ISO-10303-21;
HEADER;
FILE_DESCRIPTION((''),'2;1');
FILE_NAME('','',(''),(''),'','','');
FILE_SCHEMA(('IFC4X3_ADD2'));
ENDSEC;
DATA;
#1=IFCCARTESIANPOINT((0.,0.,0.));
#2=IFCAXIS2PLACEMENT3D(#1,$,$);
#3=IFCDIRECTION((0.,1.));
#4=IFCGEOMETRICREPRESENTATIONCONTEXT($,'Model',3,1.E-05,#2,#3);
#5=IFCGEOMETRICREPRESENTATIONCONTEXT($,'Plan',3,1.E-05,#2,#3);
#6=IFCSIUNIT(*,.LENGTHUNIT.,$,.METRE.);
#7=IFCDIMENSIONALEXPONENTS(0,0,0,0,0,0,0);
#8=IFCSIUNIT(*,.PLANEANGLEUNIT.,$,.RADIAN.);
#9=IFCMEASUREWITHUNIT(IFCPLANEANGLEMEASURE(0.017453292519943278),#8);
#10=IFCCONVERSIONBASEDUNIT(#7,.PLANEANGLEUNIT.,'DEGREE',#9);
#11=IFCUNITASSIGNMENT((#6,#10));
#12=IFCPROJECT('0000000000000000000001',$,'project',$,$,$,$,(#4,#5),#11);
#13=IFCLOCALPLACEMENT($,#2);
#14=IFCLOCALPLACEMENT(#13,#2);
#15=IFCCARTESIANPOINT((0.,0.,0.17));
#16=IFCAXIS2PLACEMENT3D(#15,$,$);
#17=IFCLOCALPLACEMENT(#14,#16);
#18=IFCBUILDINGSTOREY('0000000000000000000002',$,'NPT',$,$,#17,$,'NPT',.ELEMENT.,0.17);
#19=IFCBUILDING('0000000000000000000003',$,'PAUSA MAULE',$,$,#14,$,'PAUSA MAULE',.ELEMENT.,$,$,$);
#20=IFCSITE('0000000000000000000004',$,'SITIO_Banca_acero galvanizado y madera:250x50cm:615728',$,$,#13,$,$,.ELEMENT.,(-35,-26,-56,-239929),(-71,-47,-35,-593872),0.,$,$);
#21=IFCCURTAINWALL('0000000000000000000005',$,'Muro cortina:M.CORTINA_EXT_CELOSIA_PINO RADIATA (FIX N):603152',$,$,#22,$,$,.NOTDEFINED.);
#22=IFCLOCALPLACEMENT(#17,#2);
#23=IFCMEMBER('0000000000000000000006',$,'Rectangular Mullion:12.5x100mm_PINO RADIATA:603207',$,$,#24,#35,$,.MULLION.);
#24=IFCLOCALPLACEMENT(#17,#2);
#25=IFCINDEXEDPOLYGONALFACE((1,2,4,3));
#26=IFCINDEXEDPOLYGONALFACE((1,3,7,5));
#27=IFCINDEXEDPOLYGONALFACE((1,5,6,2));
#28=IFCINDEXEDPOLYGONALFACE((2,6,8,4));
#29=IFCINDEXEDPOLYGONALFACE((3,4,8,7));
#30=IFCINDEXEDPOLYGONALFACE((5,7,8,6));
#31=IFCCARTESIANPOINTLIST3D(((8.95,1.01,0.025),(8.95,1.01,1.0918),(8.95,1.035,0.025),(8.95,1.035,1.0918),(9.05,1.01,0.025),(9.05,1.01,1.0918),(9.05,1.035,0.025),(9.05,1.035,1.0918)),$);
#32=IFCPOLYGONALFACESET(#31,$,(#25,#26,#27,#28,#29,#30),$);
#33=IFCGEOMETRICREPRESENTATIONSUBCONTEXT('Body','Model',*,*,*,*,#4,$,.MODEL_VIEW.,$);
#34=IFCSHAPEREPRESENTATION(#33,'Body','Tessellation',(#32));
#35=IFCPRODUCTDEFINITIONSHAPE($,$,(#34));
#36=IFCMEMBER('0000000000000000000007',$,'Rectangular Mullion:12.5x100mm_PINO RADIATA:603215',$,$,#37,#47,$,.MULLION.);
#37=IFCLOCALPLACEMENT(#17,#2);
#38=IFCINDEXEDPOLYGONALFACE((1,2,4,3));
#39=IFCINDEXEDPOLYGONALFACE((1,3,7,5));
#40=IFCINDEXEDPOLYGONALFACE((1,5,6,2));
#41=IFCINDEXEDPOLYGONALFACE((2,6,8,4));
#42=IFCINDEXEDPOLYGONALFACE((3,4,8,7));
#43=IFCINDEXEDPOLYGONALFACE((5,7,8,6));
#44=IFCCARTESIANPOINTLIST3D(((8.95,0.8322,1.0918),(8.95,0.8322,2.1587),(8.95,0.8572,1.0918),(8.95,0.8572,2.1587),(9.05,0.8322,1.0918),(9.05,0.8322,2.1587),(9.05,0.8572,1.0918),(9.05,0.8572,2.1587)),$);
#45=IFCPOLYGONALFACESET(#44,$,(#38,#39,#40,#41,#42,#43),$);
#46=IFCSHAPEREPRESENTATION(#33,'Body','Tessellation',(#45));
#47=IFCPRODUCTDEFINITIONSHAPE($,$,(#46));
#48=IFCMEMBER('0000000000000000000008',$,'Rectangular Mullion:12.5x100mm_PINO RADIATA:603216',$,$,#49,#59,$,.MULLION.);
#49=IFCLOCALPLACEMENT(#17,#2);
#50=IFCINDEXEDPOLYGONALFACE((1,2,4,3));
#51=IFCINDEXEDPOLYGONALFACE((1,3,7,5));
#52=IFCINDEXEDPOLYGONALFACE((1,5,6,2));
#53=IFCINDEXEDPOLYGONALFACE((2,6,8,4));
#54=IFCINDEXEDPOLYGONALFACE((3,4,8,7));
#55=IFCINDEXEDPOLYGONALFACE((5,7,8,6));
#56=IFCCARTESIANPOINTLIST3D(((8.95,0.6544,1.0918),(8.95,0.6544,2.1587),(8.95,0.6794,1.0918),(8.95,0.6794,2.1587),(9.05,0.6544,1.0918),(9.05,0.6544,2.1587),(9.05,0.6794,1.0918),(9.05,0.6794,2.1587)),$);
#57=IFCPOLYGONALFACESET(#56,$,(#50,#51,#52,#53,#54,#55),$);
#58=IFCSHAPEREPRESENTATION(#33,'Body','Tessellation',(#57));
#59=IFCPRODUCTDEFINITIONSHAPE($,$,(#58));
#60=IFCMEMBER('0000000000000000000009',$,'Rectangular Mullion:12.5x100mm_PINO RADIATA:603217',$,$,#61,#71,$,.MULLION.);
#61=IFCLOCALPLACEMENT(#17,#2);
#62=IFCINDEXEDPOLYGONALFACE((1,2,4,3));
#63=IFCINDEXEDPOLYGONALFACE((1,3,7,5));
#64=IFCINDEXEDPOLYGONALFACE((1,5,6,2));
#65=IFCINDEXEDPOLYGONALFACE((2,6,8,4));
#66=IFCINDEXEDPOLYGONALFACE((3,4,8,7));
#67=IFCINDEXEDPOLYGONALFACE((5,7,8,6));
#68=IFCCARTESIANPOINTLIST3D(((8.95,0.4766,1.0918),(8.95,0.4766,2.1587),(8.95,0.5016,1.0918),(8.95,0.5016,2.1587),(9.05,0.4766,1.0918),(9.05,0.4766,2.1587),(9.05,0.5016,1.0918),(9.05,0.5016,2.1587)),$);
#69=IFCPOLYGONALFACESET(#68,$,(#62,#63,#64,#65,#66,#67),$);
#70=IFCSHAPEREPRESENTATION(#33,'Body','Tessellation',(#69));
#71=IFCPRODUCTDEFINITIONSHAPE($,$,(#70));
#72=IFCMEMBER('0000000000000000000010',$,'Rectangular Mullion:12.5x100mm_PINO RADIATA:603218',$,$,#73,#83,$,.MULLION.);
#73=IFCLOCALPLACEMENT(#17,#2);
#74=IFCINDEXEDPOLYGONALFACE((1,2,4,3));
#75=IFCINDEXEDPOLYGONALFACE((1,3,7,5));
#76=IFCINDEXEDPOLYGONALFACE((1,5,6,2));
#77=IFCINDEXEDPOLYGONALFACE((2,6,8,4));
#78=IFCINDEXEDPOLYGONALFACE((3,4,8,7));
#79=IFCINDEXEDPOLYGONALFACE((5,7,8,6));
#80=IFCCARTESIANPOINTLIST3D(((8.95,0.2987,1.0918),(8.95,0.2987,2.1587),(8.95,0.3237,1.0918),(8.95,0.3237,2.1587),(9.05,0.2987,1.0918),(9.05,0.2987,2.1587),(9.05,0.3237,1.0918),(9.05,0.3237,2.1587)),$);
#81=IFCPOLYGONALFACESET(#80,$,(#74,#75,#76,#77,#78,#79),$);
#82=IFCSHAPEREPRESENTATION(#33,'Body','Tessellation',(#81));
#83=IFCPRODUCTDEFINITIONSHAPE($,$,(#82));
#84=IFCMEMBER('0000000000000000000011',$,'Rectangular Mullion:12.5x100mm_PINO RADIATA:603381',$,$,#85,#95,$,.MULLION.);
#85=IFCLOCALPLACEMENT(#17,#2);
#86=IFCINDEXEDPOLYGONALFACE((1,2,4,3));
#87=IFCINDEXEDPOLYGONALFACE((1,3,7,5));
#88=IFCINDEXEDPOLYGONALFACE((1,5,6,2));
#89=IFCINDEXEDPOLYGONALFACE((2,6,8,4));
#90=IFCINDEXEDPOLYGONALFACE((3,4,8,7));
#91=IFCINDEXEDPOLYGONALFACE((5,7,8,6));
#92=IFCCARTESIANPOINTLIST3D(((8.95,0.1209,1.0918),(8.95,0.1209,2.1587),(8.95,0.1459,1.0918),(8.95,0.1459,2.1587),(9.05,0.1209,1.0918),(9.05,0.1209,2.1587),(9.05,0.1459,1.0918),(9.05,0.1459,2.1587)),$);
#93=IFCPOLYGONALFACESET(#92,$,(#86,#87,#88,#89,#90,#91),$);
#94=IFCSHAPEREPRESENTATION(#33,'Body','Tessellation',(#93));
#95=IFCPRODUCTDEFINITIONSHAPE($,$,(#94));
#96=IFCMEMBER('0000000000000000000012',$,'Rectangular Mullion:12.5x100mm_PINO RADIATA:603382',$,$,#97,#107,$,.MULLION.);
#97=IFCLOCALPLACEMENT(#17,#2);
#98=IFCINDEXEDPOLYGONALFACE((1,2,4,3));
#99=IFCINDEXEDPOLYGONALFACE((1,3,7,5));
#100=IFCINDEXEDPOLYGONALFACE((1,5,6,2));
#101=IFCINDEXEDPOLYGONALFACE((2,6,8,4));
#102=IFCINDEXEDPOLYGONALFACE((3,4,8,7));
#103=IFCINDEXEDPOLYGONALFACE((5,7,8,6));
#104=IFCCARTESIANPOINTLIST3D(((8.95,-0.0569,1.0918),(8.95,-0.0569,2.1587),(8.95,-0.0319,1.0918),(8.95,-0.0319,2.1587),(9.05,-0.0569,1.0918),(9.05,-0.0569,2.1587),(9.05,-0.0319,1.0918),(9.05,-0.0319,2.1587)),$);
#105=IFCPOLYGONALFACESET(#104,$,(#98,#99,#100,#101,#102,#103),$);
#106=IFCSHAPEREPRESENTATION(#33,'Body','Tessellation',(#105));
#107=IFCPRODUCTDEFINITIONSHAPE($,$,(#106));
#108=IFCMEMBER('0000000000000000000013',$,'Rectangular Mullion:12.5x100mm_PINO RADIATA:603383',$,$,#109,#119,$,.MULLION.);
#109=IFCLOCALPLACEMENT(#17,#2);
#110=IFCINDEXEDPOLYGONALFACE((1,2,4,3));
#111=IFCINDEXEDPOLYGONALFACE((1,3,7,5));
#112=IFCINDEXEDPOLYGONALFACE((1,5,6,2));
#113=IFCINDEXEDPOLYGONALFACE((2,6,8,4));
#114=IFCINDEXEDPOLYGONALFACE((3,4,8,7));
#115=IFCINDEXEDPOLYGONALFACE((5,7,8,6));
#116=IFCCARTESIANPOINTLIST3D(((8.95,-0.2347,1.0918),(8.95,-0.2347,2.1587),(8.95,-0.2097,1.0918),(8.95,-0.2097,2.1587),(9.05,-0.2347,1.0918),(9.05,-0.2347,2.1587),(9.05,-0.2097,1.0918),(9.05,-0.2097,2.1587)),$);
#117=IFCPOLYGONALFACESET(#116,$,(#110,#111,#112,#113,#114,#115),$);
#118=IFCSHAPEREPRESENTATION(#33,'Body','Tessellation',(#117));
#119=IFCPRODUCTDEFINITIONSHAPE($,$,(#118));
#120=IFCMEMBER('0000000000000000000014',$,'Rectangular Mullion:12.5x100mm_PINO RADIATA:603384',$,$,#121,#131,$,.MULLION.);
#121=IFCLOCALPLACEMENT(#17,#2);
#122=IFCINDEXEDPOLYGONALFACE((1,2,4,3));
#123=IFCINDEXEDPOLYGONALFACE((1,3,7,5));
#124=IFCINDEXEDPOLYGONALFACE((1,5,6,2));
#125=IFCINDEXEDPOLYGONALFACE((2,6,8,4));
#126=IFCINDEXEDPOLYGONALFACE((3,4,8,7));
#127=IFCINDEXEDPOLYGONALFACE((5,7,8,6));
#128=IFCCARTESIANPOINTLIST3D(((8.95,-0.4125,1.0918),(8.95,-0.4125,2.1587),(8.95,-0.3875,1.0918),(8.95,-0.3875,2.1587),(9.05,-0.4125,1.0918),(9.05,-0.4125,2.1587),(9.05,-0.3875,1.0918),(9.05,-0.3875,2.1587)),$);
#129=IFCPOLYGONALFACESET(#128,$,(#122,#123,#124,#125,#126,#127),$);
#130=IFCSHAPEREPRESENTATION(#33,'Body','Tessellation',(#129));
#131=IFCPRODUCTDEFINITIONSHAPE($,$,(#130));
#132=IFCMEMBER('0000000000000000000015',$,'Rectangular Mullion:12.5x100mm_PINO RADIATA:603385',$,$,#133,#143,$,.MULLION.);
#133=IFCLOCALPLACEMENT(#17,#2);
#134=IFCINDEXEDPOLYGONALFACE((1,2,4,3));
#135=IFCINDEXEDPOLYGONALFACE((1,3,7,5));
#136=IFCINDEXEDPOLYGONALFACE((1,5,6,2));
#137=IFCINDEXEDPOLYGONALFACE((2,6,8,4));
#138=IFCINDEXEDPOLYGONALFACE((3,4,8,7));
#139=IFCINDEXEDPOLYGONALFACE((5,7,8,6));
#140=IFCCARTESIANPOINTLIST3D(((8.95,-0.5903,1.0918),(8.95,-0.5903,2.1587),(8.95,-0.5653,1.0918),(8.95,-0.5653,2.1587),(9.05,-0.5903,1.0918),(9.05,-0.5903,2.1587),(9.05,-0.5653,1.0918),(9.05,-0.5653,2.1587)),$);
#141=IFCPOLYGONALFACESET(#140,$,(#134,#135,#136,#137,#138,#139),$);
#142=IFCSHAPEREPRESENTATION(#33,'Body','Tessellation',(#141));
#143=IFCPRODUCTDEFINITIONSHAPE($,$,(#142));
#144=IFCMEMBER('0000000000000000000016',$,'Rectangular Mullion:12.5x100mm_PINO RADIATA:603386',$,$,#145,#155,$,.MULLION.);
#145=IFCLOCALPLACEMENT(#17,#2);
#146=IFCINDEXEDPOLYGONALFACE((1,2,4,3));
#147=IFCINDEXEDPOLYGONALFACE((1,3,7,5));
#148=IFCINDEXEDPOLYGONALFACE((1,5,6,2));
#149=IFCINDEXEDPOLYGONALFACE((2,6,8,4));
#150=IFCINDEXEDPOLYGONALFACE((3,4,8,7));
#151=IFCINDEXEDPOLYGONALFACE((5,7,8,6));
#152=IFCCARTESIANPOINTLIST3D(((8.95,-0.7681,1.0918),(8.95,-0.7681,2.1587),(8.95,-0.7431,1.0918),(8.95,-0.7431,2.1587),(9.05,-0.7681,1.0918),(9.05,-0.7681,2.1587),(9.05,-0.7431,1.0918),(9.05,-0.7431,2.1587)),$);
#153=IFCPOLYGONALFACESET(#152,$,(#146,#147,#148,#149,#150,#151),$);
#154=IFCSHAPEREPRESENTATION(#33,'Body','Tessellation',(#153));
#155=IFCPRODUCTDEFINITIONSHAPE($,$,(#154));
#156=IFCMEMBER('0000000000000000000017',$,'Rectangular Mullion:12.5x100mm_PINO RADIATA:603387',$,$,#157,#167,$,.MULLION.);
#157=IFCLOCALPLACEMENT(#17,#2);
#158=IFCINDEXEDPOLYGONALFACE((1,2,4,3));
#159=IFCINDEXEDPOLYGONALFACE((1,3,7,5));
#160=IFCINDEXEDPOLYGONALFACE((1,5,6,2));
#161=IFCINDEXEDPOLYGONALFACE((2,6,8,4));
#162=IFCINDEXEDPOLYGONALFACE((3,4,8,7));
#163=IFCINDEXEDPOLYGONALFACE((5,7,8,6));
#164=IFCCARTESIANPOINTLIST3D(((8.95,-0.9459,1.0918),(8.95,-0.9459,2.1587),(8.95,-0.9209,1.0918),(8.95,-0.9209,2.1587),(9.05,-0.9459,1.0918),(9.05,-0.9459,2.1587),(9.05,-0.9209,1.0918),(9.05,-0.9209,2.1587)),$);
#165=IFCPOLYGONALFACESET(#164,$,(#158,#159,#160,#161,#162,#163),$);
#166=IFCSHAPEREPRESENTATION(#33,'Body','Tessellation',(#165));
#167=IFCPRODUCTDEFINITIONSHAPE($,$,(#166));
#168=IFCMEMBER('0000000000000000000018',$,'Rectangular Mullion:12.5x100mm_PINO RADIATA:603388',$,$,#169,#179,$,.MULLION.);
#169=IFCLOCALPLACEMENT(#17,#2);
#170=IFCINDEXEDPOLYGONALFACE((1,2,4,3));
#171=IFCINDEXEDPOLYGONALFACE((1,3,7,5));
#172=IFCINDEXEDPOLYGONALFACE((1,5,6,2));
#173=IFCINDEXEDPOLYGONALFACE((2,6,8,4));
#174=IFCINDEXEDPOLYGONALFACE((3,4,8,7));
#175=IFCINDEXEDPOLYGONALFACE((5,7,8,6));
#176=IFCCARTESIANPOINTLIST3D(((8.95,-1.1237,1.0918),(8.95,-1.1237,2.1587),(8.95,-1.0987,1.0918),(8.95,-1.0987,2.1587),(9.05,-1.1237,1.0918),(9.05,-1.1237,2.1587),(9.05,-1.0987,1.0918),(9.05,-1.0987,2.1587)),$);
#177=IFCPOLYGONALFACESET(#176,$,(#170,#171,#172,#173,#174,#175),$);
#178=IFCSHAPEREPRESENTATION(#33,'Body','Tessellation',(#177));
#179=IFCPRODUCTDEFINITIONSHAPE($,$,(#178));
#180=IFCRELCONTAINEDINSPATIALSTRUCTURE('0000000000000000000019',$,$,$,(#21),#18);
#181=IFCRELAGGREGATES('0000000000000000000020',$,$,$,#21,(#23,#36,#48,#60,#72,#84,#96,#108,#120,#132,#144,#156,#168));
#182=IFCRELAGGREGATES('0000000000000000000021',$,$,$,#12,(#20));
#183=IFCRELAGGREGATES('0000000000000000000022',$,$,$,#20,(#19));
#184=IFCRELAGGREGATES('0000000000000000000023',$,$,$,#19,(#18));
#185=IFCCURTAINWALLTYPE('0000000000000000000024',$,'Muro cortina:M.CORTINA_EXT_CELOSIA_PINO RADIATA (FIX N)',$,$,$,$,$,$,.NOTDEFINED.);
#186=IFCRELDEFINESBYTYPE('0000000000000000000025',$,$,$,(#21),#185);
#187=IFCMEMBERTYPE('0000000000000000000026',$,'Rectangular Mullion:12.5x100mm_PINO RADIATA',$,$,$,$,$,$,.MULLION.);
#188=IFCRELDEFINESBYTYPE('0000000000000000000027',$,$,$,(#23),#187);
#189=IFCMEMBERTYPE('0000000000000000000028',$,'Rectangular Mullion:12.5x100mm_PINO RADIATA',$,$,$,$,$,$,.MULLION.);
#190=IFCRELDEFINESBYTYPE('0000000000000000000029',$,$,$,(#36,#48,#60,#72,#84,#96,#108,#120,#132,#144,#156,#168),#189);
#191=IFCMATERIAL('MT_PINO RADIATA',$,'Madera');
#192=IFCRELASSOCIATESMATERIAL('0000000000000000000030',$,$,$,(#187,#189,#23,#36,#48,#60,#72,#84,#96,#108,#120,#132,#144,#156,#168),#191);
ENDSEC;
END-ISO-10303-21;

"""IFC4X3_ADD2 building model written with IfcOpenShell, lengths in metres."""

from ifc_helpers import new_model, entity, si_unit, converted_unit, direction, frame, frame_2d, origin, origin_2d_with_axis, place, context, subcontext, project, spatial, rectangle, extrude, source, transform, mapped, material, material_profile, profile_set, profile_usage, type_object, type_shapes, element, aggregate, save


model = new_model("IFC4X3_ADD2")

# Units and contexts
model_context = context("Model", 3, precision=1e-05, world=origin(), true_north=direction((0.0, 1.0)))
plan_context = context("Plan", 3, precision=1e-05, world=origin(), true_north=direction((0.0, 1.0)))
body_context = subcontext(model_context, "Body", "Model", "MODEL_VIEW")
ifc_project = project(units=[si_unit("LENGTHUNIT", "METRE"), converted_unit("PLANEANGLEUNIT", "DEGREE", entity("IfcPlaneAngleMeasure", 0.017453292519943278), si_unit("PLANEANGLEUNIT", "RADIAN"), dimensions=[0, 0, 0, 0, 0, 0, 0])], contexts=[model_context, plan_context])

# Site, building, storey
site_placement = place(None, origin())
site = spatial("IfcSite", under=ifc_project, at=site_placement, Name="SITIO_Banca_acero galvanizado y madera:250x50cm:615728", CompositionType="ELEMENT", RefLatitude=(-35, -26, -56, -239929), RefLongitude=(-71, -47, -35, -593872), RefElevation=0.0)
building_placement = place(site_placement, origin())
building = spatial("IfcBuilding", under=site, at=building_placement, Name="PAUSA MAULE", LongName="PAUSA MAULE", CompositionType="ELEMENT")
storey_placement = place(building_placement, frame((0.0, 0.0, 0.17)))
storey = spatial("IfcBuildingStorey", under=building, at=storey_placement, Name="NPT", LongName="NPT", CompositionType="ELEMENT", Elevation=0.17)

# Curtain wall, members
curtain_wall_type = type_object("IfcCurtainWallType", Name="Muro cortina:M.CORTINA_EXT_CELOSIA_PINO RADIATA (FIX N)", PredefinedType="NOTDEFINED")
curtain_wall_placement = place(storey_placement, frame((0.0, 0.0, -0.17)))
curtain_wall = element("IfcCurtainWall", 1, at=curtain_wall_placement, inside=storey, type_object=curtain_wall_type, Name="Muro cortina:M.CORTINA_EXT_CELOSIA_PINO RADIATA (FIX N):603152", PredefinedType="NOTDEFINED")
ifc_material = material(Name="MT_PINO RADIATA", Category="Madera")
ifc_material_profile = material_profile(ifc_material, rectangle(XDim=0.025, YDim=0.1, at=frame_2d((0.0, 0.0), x_axis=(1.0, 0.0))), Name="12.5x100mm_PINO RADIATA")
ifc_profile_set = profile_set([ifc_material_profile], Name="12.5x100mm_PINO RADIATA")
ifc_profile_usage = profile_usage(ifc_profile_set)
member_type_1 = type_object("IfcMemberType", Name="Rectangular Mullion:12.5x100mm_PINO RADIATA", PredefinedType="MULLION", material=ifc_profile_set)
shared_shape_1 = source(origin(), body_context, "Body", "SweptSolid", [
    extrude(rectangle(XDim=0.025, YDim=0.1, at=frame_2d((0.0, 0.0), x_axis=(1.0, 0.0))), frame((-0.0125, 0.0, -1.0668), z_axis=(0.0, 0.0, 1.0), x_axis=(-1.0, 0.0, 0.0)), (0.0, 0.0, 1.0), 1.0668),
])
type_shapes(member_type_1, [shared_shape_1])
member_1_placement = place(curtain_wall_placement, frame((9.0, 1.035, 1.2618), z_axis=(0.0, 0.0, 1.0), x_axis=(0.0, 1.0, 0.0)))
member_1 = element("IfcMember", 2, at=member_1_placement, type_object=member_type_1, material=ifc_profile_usage, Name="Rectangular Mullion:12.5x100mm_PINO RADIATA:603207", PredefinedType="MULLION", context=body_context, shape_type="MappedRepresentation", body=[
    mapped(shared_shape_1, transform((0.0, 0.0, 0.0), scale=1.0)),
])
member_type_2 = type_object("IfcMemberType", Name="Rectangular Mullion:12.5x100mm_PINO RADIATA", PredefinedType="MULLION", material=ifc_profile_set)
shared_shape_2 = source(origin(), body_context, "Body", "SweptSolid", [
    extrude(rectangle(XDim=0.025, YDim=0.1, at=origin_2d_with_axis()), frame((0.0, 0.0, -1.0668), z_axis=(0.0, 0.0, 1.0), x_axis=(-1.0, 0.0, 0.0)), (0.0, 0.0, 1.0), 1.0668),
])
type_shapes(member_type_2, [shared_shape_2])
member_2_placement = place(curtain_wall_placement, frame((9.0, 0.8447, 1.2618), z_axis=(0.0, 0.0, -1.0), x_axis=(0.0, -1.0, 0.0)))
member_2 = element("IfcMember", 3, at=member_2_placement, type_object=member_type_2, material=ifc_profile_usage, Name="Rectangular Mullion:12.5x100mm_PINO RADIATA:603215", PredefinedType="MULLION", context=body_context, shape_type="MappedRepresentation", body=[
    mapped(shared_shape_2, transform((0.0, 0.0, 0.0), scale=1.0)),
])
member_3_placement = place(curtain_wall_placement, frame((9.0, 0.6669, 1.2618), z_axis=(0.0, 0.0, -1.0), x_axis=(0.0, -1.0, 0.0)))
member_3 = element("IfcMember", 4, at=member_3_placement, type_object=member_type_2, material=ifc_profile_usage, Name="Rectangular Mullion:12.5x100mm_PINO RADIATA:603216", PredefinedType="MULLION", context=body_context, shape_type="MappedRepresentation", body=[
    mapped(shared_shape_2, transform((0.0, 0.0, 0.0), scale=1.0)),
])
member_4_placement = place(curtain_wall_placement, frame((9.0, 0.4891, 1.2618), z_axis=(0.0, 0.0, -1.0), x_axis=(0.0, -1.0, 0.0)))
member_4 = element("IfcMember", 5, at=member_4_placement, type_object=member_type_2, material=ifc_profile_usage, Name="Rectangular Mullion:12.5x100mm_PINO RADIATA:603217", PredefinedType="MULLION", context=body_context, shape_type="MappedRepresentation", body=[
    mapped(shared_shape_2, transform((0.0, 0.0, 0.0), scale=1.0)),
])
member_5_placement = place(curtain_wall_placement, frame((9.0, 0.3112, 1.2618), z_axis=(0.0, 0.0, -1.0), x_axis=(0.0, -1.0, 0.0)))
member_5 = element("IfcMember", 6, at=member_5_placement, type_object=member_type_2, material=ifc_profile_usage, Name="Rectangular Mullion:12.5x100mm_PINO RADIATA:603218", PredefinedType="MULLION", context=body_context, shape_type="MappedRepresentation", body=[
    mapped(shared_shape_2, transform((0.0, 0.0, 0.0), scale=1.0)),
])
member_6_placement = place(curtain_wall_placement, frame((9.0, 0.1334, 1.2618), z_axis=(0.0, 0.0, -1.0), x_axis=(0.0, -1.0, 0.0)))
member_6 = element("IfcMember", 7, at=member_6_placement, type_object=member_type_2, material=ifc_profile_usage, Name="Rectangular Mullion:12.5x100mm_PINO RADIATA:603381", PredefinedType="MULLION", context=body_context, shape_type="MappedRepresentation", body=[
    mapped(shared_shape_2, transform((0.0, 0.0, 0.0), scale=1.0)),
])
member_7_placement = place(curtain_wall_placement, frame((9.0, -0.0444, 1.2618), z_axis=(0.0, 0.0, -1.0), x_axis=(0.0, -1.0, 0.0)))
member_7 = element("IfcMember", 8, at=member_7_placement, type_object=member_type_2, material=ifc_profile_usage, Name="Rectangular Mullion:12.5x100mm_PINO RADIATA:603382", PredefinedType="MULLION", context=body_context, shape_type="MappedRepresentation", body=[
    mapped(shared_shape_2, transform((0.0, 0.0, 0.0), scale=1.0)),
])
member_8_placement = place(curtain_wall_placement, frame((9.0, -0.2222, 1.2618), z_axis=(0.0, 0.0, -1.0), x_axis=(0.0, -1.0, 0.0)))
member_8 = element("IfcMember", 9, at=member_8_placement, type_object=member_type_2, material=ifc_profile_usage, Name="Rectangular Mullion:12.5x100mm_PINO RADIATA:603383", PredefinedType="MULLION", context=body_context, shape_type="MappedRepresentation", body=[
    mapped(shared_shape_2, transform((0.0, 0.0, 0.0), scale=1.0)),
])
member_9_placement = place(curtain_wall_placement, frame((9.0, -0.4, 1.2618), z_axis=(0.0, 0.0, -1.0), x_axis=(0.0, -1.0, 0.0)))
member_9 = element("IfcMember", 10, at=member_9_placement, type_object=member_type_2, material=ifc_profile_usage, Name="Rectangular Mullion:12.5x100mm_PINO RADIATA:603384", PredefinedType="MULLION", context=body_context, shape_type="MappedRepresentation", body=[
    mapped(shared_shape_2, transform((0.0, 0.0, 0.0), scale=1.0)),
])
member_10_placement = place(curtain_wall_placement, frame((9.0, -0.5778, 1.2618), z_axis=(0.0, 0.0, -1.0), x_axis=(0.0, -1.0, 0.0)))
member_10 = element("IfcMember", 11, at=member_10_placement, type_object=member_type_2, material=ifc_profile_usage, Name="Rectangular Mullion:12.5x100mm_PINO RADIATA:603385", PredefinedType="MULLION", context=body_context, shape_type="MappedRepresentation", body=[
    mapped(shared_shape_2, transform((0.0, 0.0, 0.0), scale=1.0)),
])
member_11_placement = place(curtain_wall_placement, frame((9.0, -0.7556, 1.2618), z_axis=(0.0, 0.0, -1.0), x_axis=(0.0, -1.0, 0.0)))
member_11 = element("IfcMember", 12, at=member_11_placement, type_object=member_type_2, material=ifc_profile_usage, Name="Rectangular Mullion:12.5x100mm_PINO RADIATA:603386", PredefinedType="MULLION", context=body_context, shape_type="MappedRepresentation", body=[
    mapped(shared_shape_2, transform((0.0, 0.0, 0.0), scale=1.0)),
])
member_12_placement = place(curtain_wall_placement, frame((9.0, -0.9334, 1.2618), z_axis=(0.0, 0.0, -1.0), x_axis=(0.0, -1.0, 0.0)))
member_12 = element("IfcMember", 13, at=member_12_placement, type_object=member_type_2, material=ifc_profile_usage, Name="Rectangular Mullion:12.5x100mm_PINO RADIATA:603387", PredefinedType="MULLION", context=body_context, shape_type="MappedRepresentation", body=[
    mapped(shared_shape_2, transform((0.0, 0.0, 0.0), scale=1.0)),
])
member_13_placement = place(curtain_wall_placement, frame((9.0, -1.1112, 1.2618), z_axis=(0.0, 0.0, -1.0), x_axis=(0.0, -1.0, 0.0)))
member_13 = element("IfcMember", 14, at=member_13_placement, type_object=member_type_2, material=ifc_profile_usage, Name="Rectangular Mullion:12.5x100mm_PINO RADIATA:603388", PredefinedType="MULLION", context=body_context, shape_type="MappedRepresentation", body=[
    mapped(shared_shape_2, transform((0.0, 0.0, 0.0), scale=1.0)),
])
aggregate(curtain_wall, [member_1, member_2, member_3, member_4, member_5, member_6, member_7, member_8, member_9, member_10, member_11, member_12, member_13])

save(model, "model.ifc")
